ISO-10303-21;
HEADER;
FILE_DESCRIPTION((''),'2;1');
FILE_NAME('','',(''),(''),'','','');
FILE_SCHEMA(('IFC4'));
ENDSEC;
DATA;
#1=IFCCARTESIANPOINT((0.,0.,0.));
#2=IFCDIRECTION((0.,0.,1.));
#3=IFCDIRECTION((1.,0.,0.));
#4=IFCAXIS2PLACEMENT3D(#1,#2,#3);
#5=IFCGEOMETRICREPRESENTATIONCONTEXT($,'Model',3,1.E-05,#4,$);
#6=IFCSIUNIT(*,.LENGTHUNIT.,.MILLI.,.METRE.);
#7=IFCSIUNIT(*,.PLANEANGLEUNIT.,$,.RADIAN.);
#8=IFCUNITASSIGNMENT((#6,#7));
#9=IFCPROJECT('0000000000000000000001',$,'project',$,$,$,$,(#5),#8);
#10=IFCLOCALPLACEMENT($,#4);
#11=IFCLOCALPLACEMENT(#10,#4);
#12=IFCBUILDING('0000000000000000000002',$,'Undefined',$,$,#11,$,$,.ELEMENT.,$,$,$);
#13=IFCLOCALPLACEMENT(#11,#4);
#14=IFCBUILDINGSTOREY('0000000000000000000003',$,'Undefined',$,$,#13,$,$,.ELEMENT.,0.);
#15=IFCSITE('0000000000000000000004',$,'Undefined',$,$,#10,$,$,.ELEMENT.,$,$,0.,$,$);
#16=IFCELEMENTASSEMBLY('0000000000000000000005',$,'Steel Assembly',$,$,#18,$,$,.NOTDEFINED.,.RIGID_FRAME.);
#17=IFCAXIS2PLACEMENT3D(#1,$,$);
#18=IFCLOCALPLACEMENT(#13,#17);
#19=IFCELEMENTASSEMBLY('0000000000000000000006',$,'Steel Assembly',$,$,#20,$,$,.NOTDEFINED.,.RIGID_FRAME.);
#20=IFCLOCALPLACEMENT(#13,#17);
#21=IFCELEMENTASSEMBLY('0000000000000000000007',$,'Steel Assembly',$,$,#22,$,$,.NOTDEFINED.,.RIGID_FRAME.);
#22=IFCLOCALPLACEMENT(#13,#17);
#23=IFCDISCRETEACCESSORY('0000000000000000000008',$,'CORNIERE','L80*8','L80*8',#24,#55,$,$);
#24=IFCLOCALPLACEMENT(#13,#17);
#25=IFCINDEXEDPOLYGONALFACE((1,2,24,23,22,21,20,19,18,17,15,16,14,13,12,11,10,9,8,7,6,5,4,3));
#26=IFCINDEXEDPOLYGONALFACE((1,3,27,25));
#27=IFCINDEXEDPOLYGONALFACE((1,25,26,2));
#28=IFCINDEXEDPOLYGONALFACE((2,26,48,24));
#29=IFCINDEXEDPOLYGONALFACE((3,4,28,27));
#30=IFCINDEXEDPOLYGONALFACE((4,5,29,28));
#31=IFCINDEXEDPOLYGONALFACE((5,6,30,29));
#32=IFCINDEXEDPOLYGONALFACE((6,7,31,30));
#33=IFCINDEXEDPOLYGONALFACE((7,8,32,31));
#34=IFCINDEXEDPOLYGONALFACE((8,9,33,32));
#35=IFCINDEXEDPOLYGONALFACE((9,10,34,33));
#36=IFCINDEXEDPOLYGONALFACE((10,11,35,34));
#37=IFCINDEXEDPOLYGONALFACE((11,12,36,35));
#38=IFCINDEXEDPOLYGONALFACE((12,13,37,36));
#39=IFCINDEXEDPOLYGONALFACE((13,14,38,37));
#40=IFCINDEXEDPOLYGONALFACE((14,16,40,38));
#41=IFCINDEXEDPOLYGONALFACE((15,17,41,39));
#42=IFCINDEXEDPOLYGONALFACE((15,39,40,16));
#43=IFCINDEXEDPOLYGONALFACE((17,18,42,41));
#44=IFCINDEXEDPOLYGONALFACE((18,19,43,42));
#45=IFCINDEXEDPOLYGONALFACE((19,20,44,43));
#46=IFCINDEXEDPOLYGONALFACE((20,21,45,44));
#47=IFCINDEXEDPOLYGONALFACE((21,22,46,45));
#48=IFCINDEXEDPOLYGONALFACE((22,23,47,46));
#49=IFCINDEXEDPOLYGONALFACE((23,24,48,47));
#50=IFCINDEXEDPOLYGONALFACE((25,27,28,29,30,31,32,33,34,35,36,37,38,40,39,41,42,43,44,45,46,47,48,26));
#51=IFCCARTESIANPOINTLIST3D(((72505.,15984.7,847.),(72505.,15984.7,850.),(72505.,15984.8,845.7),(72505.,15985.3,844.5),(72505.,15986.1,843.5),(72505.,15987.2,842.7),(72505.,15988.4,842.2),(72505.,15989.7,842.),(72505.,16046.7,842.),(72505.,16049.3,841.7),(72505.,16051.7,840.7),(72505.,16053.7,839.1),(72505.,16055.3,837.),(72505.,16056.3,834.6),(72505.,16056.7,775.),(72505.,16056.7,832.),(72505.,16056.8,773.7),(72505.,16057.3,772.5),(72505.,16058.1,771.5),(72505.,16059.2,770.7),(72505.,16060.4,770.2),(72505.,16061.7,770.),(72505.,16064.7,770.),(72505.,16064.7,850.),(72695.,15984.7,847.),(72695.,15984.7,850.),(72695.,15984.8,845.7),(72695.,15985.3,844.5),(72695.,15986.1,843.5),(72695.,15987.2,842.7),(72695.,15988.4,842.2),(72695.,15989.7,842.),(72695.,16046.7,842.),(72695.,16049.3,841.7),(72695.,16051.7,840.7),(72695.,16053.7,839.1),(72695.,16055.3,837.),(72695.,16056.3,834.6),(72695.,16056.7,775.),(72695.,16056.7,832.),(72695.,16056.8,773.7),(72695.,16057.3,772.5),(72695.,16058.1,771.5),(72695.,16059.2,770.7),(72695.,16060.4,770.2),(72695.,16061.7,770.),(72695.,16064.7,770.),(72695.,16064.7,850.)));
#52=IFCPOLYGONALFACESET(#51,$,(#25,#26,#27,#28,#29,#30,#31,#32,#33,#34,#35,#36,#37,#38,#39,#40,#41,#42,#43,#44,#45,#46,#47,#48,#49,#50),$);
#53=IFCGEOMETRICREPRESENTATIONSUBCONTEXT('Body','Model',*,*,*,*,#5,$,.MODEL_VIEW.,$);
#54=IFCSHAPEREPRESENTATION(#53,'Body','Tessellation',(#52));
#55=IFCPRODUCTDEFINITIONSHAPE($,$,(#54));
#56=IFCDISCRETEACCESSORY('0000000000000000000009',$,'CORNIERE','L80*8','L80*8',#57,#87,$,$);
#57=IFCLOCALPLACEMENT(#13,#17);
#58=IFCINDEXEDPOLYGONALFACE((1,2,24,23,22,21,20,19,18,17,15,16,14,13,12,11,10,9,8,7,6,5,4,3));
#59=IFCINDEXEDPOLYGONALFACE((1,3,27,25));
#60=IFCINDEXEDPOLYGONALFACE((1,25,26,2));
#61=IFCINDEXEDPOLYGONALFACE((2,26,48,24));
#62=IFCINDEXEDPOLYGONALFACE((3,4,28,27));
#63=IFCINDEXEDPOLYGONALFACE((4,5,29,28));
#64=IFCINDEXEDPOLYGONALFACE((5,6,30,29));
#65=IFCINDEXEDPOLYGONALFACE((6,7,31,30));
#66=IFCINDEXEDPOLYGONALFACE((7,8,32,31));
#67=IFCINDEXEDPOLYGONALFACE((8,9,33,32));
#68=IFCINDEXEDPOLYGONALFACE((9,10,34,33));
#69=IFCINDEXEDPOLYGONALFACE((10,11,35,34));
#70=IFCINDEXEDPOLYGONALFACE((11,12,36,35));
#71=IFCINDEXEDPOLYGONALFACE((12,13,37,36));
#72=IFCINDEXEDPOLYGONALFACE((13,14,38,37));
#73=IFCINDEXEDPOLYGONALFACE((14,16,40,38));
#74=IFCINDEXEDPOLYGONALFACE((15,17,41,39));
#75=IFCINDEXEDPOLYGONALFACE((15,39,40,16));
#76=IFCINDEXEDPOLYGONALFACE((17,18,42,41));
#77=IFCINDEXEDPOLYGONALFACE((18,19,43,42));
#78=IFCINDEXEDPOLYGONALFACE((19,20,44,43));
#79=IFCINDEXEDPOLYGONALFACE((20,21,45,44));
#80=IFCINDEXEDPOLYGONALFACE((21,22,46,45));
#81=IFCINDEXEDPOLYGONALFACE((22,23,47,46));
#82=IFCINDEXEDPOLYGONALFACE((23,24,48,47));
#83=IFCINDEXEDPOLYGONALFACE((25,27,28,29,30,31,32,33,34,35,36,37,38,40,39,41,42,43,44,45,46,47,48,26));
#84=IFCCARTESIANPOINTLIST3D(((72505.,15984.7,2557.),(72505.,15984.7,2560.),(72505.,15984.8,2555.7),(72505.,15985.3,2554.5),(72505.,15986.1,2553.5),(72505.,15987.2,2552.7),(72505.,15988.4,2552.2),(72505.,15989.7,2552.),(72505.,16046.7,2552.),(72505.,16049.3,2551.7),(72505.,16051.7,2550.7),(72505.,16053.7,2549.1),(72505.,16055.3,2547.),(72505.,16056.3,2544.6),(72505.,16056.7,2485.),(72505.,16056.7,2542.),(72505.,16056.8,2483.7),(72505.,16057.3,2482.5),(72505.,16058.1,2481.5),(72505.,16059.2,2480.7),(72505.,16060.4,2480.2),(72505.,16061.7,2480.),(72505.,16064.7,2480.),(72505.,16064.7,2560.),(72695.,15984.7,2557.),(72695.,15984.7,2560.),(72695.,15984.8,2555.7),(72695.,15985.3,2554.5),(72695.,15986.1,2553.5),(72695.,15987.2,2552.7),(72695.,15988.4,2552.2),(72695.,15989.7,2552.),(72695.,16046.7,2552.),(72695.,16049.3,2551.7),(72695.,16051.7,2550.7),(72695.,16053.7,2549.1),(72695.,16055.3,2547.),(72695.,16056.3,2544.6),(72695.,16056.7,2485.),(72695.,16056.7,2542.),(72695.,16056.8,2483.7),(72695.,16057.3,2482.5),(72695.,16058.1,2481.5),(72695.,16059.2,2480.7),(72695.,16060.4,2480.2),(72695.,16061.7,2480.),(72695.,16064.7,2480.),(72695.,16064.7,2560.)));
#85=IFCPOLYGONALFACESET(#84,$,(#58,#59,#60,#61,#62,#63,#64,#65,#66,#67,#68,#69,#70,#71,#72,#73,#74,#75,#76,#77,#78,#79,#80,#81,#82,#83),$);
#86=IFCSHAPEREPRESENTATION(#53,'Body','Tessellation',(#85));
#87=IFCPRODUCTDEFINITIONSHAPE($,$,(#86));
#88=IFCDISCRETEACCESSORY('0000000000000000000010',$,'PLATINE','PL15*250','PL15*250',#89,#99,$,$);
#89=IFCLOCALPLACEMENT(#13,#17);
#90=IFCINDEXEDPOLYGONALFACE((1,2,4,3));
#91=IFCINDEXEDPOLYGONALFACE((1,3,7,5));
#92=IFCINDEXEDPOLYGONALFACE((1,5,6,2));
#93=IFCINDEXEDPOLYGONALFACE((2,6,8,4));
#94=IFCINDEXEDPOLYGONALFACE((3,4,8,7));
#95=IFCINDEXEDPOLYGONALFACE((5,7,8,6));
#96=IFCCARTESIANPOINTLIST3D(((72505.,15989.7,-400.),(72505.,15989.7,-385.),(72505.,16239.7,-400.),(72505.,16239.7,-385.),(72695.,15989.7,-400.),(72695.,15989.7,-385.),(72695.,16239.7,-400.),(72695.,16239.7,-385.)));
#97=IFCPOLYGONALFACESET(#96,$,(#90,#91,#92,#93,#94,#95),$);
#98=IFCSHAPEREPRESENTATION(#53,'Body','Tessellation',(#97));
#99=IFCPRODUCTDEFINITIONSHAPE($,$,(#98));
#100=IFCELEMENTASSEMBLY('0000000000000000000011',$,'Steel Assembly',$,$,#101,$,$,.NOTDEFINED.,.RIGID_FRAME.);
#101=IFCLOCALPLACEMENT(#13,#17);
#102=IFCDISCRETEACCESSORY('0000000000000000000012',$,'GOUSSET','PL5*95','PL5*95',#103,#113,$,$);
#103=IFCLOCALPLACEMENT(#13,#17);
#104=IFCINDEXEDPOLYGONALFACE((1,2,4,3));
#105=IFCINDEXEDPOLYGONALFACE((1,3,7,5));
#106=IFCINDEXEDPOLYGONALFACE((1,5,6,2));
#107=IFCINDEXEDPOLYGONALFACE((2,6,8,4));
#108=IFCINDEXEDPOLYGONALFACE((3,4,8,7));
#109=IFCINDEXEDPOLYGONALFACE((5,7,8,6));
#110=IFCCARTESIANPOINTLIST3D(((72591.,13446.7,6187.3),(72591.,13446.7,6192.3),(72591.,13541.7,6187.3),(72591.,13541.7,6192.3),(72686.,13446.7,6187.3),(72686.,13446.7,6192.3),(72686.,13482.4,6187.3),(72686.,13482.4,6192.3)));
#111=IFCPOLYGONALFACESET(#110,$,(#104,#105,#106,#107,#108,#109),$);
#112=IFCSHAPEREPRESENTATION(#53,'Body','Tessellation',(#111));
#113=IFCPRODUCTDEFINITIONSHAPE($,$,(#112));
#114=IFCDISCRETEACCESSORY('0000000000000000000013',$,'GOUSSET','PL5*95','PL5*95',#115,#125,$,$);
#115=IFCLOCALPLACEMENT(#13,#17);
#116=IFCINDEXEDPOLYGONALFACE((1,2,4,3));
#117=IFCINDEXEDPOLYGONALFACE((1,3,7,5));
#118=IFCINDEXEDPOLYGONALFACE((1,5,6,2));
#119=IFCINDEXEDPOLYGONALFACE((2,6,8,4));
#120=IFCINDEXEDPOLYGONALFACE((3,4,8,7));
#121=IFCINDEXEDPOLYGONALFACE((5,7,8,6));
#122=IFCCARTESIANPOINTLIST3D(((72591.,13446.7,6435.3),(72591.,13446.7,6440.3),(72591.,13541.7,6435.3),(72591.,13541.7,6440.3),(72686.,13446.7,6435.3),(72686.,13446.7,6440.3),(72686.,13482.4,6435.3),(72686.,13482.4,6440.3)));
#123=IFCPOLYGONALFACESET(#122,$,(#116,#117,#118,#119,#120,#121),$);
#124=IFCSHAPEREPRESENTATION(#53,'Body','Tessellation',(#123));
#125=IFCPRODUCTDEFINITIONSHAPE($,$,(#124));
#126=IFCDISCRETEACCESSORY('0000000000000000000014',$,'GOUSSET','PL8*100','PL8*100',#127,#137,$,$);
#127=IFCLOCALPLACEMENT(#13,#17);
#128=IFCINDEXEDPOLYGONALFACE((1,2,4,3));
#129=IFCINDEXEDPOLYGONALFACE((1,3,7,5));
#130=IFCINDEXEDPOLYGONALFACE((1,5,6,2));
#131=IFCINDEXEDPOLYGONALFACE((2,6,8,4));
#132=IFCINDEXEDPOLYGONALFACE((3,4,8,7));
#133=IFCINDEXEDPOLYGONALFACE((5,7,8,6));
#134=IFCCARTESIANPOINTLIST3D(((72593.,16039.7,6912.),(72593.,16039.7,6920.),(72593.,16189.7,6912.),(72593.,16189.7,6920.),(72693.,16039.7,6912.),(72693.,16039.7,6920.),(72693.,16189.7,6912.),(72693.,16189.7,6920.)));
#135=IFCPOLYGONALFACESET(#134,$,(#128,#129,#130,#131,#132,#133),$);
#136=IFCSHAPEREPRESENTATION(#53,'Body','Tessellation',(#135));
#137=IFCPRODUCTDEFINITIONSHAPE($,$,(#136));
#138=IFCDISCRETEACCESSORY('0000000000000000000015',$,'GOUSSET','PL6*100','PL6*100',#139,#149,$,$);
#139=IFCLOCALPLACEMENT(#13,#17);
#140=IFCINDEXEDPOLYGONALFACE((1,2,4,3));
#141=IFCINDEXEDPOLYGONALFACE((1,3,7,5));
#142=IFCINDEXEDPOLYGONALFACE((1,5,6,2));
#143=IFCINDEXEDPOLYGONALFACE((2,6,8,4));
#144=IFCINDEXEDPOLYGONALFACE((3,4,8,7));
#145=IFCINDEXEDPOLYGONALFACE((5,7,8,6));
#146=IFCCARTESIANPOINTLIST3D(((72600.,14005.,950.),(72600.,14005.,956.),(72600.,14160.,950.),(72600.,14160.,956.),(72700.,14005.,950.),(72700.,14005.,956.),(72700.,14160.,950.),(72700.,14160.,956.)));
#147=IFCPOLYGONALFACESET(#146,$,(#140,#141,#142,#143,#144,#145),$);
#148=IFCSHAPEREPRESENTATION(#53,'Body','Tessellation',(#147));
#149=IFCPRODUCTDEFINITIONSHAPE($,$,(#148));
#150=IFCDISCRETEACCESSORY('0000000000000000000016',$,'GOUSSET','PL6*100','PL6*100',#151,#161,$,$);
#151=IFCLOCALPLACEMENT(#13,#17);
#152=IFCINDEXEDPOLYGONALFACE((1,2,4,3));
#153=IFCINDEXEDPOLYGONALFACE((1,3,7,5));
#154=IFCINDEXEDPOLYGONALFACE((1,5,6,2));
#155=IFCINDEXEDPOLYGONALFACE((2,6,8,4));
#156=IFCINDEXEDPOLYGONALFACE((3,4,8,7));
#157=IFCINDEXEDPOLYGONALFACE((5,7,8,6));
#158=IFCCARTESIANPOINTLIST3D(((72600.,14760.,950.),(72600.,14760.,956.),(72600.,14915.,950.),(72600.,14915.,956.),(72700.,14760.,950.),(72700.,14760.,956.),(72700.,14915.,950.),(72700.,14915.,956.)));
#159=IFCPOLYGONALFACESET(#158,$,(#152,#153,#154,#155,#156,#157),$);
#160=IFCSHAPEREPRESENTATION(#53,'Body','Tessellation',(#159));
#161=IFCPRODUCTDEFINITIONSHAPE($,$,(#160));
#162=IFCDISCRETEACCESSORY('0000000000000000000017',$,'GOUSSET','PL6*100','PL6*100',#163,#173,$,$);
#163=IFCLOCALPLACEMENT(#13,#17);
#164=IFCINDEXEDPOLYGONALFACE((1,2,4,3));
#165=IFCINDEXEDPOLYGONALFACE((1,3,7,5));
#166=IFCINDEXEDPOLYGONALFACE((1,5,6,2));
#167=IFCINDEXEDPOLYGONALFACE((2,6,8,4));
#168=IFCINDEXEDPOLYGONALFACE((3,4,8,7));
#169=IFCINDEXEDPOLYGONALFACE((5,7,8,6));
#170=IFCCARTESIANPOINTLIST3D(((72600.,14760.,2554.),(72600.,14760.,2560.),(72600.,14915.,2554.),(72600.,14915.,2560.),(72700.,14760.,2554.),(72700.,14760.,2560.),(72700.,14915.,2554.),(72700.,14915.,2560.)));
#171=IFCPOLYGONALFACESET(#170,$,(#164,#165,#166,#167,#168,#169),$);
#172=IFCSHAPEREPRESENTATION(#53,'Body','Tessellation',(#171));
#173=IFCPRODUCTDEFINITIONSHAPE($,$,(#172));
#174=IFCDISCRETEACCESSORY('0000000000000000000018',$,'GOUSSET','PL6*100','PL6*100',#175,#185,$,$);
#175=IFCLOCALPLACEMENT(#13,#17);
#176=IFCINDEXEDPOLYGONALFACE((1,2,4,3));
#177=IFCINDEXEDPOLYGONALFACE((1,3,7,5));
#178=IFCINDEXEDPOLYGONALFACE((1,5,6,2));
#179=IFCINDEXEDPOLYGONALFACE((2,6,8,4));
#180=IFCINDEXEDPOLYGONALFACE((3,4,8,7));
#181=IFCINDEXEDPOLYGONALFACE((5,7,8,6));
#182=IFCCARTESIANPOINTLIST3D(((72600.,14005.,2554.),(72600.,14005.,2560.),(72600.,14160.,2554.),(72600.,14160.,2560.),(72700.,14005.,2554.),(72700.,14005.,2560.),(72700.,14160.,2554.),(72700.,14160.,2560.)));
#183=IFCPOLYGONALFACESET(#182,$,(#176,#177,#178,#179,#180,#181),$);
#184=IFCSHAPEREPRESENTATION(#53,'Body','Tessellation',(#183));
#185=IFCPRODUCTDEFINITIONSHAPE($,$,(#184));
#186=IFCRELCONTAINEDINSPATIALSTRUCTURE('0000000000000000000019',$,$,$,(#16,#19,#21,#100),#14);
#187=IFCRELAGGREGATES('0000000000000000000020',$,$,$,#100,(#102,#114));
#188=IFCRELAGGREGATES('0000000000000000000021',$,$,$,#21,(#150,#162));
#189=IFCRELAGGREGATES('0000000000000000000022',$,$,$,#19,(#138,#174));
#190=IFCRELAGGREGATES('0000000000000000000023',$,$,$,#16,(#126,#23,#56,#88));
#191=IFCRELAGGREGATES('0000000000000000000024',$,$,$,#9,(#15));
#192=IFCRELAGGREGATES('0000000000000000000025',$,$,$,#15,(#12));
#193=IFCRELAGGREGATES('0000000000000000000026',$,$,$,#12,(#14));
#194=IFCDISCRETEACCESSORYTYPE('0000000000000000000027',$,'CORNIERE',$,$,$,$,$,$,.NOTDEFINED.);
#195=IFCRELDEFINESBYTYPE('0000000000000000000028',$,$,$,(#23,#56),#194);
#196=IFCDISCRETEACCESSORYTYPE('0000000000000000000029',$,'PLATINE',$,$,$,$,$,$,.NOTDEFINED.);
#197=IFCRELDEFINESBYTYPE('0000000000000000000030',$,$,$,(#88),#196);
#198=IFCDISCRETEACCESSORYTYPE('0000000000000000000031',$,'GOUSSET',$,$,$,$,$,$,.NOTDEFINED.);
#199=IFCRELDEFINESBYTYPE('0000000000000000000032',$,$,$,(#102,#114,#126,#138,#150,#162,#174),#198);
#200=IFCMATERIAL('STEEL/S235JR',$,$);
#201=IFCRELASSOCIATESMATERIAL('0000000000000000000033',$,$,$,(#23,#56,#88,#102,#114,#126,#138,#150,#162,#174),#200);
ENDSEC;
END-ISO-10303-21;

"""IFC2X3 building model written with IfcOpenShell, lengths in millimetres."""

from ifc_helpers import new_model, si_unit, frame, origin_with_axes, origin_2d_with_axis, place, context, subcontext, project, spatial, polyline, l_section, outline, extrude, material, type_object, element, aggregate, save


model = new_model("IFC2X3")

# Units and contexts
model_context = context("Model", 3, precision=1e-05, world=origin_with_axes())
body_context = subcontext(model_context, "Body", "Model", "MODEL_VIEW")
ifc_project = project(units=[si_unit("LENGTHUNIT", "METRE", prefix="MILLI"), si_unit("PLANEANGLEUNIT", "RADIAN")], contexts=[model_context])

# Site, building, storey
site_placement = place(None, origin_with_axes())
site = spatial("IfcSite", under=ifc_project, at=site_placement, Name="Undefined", CompositionType="ELEMENT", RefElevation=0.0)
building_placement = place(site_placement, origin_with_axes())
building = spatial("IfcBuilding", under=site, at=building_placement, Name="Undefined", CompositionType="ELEMENT")
storey_placement = place(building_placement, origin_with_axes())
storey = spatial("IfcBuildingStorey", under=building, at=storey_placement, Name="Undefined", CompositionType="ELEMENT", Elevation=0.0)

# Element assembly
assembly_1_placement = place(storey_placement, origin_with_axes())
assembly_1 = element("IfcElementAssembly", 1, at=assembly_1_placement, inside=storey, Name="Steel Assembly", AssemblyPlace="NOTDEFINED", PredefinedType="RIGID_FRAME")
ifc_material_1 = material(Name="STEEL/S235JR")

# Element assemblies
assembly_2_placement = place(storey_placement, origin_with_axes())
assembly_2 = element("IfcElementAssembly", 2, at=assembly_2_placement, inside=storey, Name="Steel Assembly", AssemblyPlace="NOTDEFINED", PredefinedType="RIGID_FRAME")
assembly_3_placement = place(storey_placement, origin_with_axes())
assembly_3 = element("IfcElementAssembly", 3, at=assembly_3_placement, inside=storey, Name="Steel Assembly", AssemblyPlace="NOTDEFINED", PredefinedType="RIGID_FRAME")

# Discrete accessories
discrete_accessory_type_1 = type_object("IfcDiscreteAccessoryType", Name="CORNIERE")
discrete_accessory_1_placement = place(assembly_1_placement, frame((72695.0, 16024.7, 810.0), z_axis=(0.0, 0.0, -1.0), x_axis=(-1.0, 0.0, 0.0)))
discrete_accessory_1 = element("IfcDiscreteAccessory", 4, at=discrete_accessory_1_placement, type_object=discrete_accessory_type_1, material=ifc_material_1, Name="CORNIERE", Description="L80*8", ObjectType="L80*8", context=body_context, shape_type="SweptSolid", body=[
    extrude(l_section(Depth=80.0, Width=80.0, Thickness=8.0, FilletRadius=10.0, EdgeRadius=5.0, at=origin_2d_with_axis()), frame((190.0, 0.0, 0.0), z_axis=(-1.0, 0.0, 0.0), x_axis=(0.0, -1.0, 0.0)), (0.0, 0.0, 1.0), 190.0),
])
discrete_accessory_2_placement = place(assembly_1_placement, frame((72695.0, 16024.7, 2520.0), z_axis=(0.0, 0.0, -1.0), x_axis=(-1.0, 0.0, 0.0)))
discrete_accessory_2 = element("IfcDiscreteAccessory", 5, at=discrete_accessory_2_placement, type_object=discrete_accessory_type_1, material=ifc_material_1, Name="CORNIERE", Description="L80*8", ObjectType="L80*8", context=body_context, shape_type="SweptSolid", body=[
    extrude(l_section(Depth=80.0, Width=80.0, Thickness=8.0, FilletRadius=10.0, EdgeRadius=5.0, at=origin_2d_with_axis()), frame((190.0, 0.0, 0.0), z_axis=(-1.0, 0.0, 0.0), x_axis=(0.0, -1.0, 0.0)), (0.0, 0.0, 1.0), 190.0),
])
discrete_accessory_type_2 = type_object("IfcDiscreteAccessoryType", Name="PLATINE")
discrete_accessory_3_placement = place(assembly_1_placement, frame((72505.0, 16114.7, -392.5), z_axis=(0.0, 0.0, 1.0), x_axis=(1.0, 0.0, 0.0)))
discrete_accessory_3 = element("IfcDiscreteAccessory", 6, at=discrete_accessory_3_placement, type_object=discrete_accessory_type_2, material=ifc_material_1, Name="PLATINE", Description="PL15*250", ObjectType="PL15*250", context=body_context, shape_type="SweptSolid", body=[
    extrude(outline(polyline([(0.0, 125.0), (190.0, 125.0), (190.0, -125.0), (0.0, -125.0), (0.0, 125.0)])), frame((0.0, 0.0, -7.5), z_axis=(0.0, 0.0, 1.0), x_axis=(1.0, 0.0, 0.0)), (0.0, 0.0, 1.0), 15.0),
])

# Element assembly, discrete accessories
assembly_4_placement = place(storey_placement, origin_with_axes())
assembly_4 = element("IfcElementAssembly", 7, at=assembly_4_placement, inside=storey, Name="Steel Assembly", AssemblyPlace="NOTDEFINED", PredefinedType="RIGID_FRAME")
discrete_accessory_type_3 = type_object("IfcDiscreteAccessoryType", Name="GOUSSET")
discrete_accessory_4_placement = place(assembly_4_placement, frame((72686.0, 13446.7, 6189.8), z_axis=(0.0, 0.0, -1.0), x_axis=(-1.0, 0.0, 0.0)))
discrete_accessory_4 = element("IfcDiscreteAccessory", 8, at=discrete_accessory_4_placement, type_object=discrete_accessory_type_3, material=ifc_material_1, Name="GOUSSET", Description="PL5*95", ObjectType="PL5*95", context=body_context, shape_type="SweptSolid", body=[
    extrude(outline(polyline([(0.0, 0.0), (95.0, 0.0), (95.0, 95.0), (0.0, 35.7), (0.0, 0.0)])), frame((0.0, 0.0, -2.5), z_axis=(0.0, 0.0, 1.0), x_axis=(1.0, 0.0, 0.0)), (0.0, 0.0, 1.0), 5.0),
])
discrete_accessory_5_placement = place(assembly_4_placement, frame((72686.0, 13446.7, 6437.8), z_axis=(0.0, 0.0, -1.0), x_axis=(-1.0, 0.0, 0.0)))
discrete_accessory_5 = element("IfcDiscreteAccessory", 9, at=discrete_accessory_5_placement, type_object=discrete_accessory_type_3, material=ifc_material_1, Name="GOUSSET", Description="PL5*95", ObjectType="PL5*95", context=body_context, shape_type="SweptSolid", body=[
    extrude(outline(polyline([(0.0, 0.0), (95.0, 0.0), (95.0, 95.0), (0.0, 35.7), (0.0, 0.0)])), frame((0.0, 0.0, -2.5), z_axis=(0.0, 0.0, 1.0), x_axis=(1.0, 0.0, 0.0)), (0.0, 0.0, 1.0), 5.0),
])
aggregate(assembly_4, [discrete_accessory_4, discrete_accessory_5])

# Discrete accessories
discrete_accessory_6_placement = place(assembly_1_placement, frame((72693.0, 16039.7, 6916.0), z_axis=(0.0, 0.0, 1.0), x_axis=(0.0, 1.0, 0.0)))
discrete_accessory_6 = element("IfcDiscreteAccessory", 10, at=discrete_accessory_6_placement, type_object=discrete_accessory_type_3, material=ifc_material_1, Name="GOUSSET", Description="PL8*100", ObjectType="PL8*100", context=body_context, shape_type="SweptSolid", body=[
    extrude(outline(polyline([(0.0, 0.0), (150.0, 0.0), (150.0, 100.0), (0.0, 100.0), (0.0, 0.0)])), frame((0.0, 0.0, -4.0), z_axis=(0.0, 0.0, 1.0), x_axis=(1.0, 0.0, 0.0)), (0.0, 0.0, 1.0), 8.0),
])
discrete_accessory_7_placement = place(assembly_2_placement, frame((72600.0, 14160.0, 953.0), z_axis=(0.0, 0.0, 1.0), x_axis=(0.0, -1.0, 0.0)))
discrete_accessory_7 = element("IfcDiscreteAccessory", 11, at=discrete_accessory_7_placement, type_object=discrete_accessory_type_3, material=ifc_material_1, Name="GOUSSET", Description="PL6*100", ObjectType="PL6*100", context=body_context, shape_type="SweptSolid", body=[
    extrude(outline(polyline([(0.0, 0.0), (155.0, 0.0), (155.0, 100.0), (0.0, 100.0), (0.0, 0.0)])), frame((0.0, 0.0, -3.0), z_axis=(0.0, 0.0, 1.0), x_axis=(1.0, 0.0, 0.0)), (0.0, 0.0, 1.0), 6.0),
])
discrete_accessory_8_placement = place(assembly_3_placement, frame((72700.0, 14760.0, 953.0), z_axis=(0.0, 0.0, 1.0), x_axis=(0.0, 1.0, 0.0)))
discrete_accessory_8 = element("IfcDiscreteAccessory", 12, at=discrete_accessory_8_placement, type_object=discrete_accessory_type_3, material=ifc_material_1, Name="GOUSSET", Description="PL6*100", ObjectType="PL6*100", context=body_context, shape_type="SweptSolid", body=[
    extrude(outline(polyline([(0.0, 0.0), (155.0, 0.0), (155.0, 100.0), (0.0, 100.0), (0.0, 0.0)])), frame((0.0, 0.0, -3.0), z_axis=(0.0, 0.0, 1.0), x_axis=(1.0, 0.0, 0.0)), (0.0, 0.0, 1.0), 6.0),
])
discrete_accessory_9_placement = place(assembly_3_placement, frame((72600.0, 14760.0, 2557.0), z_axis=(0.0, 0.0, -1.0), x_axis=(0.0, 1.0, 0.0)))
discrete_accessory_9 = element("IfcDiscreteAccessory", 13, at=discrete_accessory_9_placement, type_object=discrete_accessory_type_3, material=ifc_material_1, Name="GOUSSET", Description="PL6*100", ObjectType="PL6*100", context=body_context, shape_type="SweptSolid", body=[
    extrude(outline(polyline([(0.0, 0.0), (155.0, 0.0), (155.0, 100.0), (0.0, 100.0), (0.0, 0.0)])), frame((0.0, 0.0, -3.0), z_axis=(0.0, 0.0, 1.0), x_axis=(1.0, 0.0, 0.0)), (0.0, 0.0, 1.0), 6.0),
])
aggregate(assembly_3, [discrete_accessory_8, discrete_accessory_9])
discrete_accessory_10_placement = place(assembly_2_placement, frame((72700.0, 14160.0, 2557.0), z_axis=(0.0, 0.0, -1.0), x_axis=(0.0, -1.0, 0.0)))
discrete_accessory_10 = element("IfcDiscreteAccessory", 14, at=discrete_accessory_10_placement, type_object=discrete_accessory_type_3, material=ifc_material_1, Name="GOUSSET", Description="PL6*100", ObjectType="PL6*100", context=body_context, shape_type="SweptSolid", body=[
    extrude(outline(polyline([(0.0, 0.0), (155.0, 0.0), (155.0, 100.0), (0.0, 100.0), (0.0, 0.0)])), frame((0.0, 0.0, -3.0), z_axis=(0.0, 0.0, 1.0), x_axis=(1.0, 0.0, 0.0)), (0.0, 0.0, 1.0), 6.0),
])
aggregate(assembly_2, [discrete_accessory_7, discrete_accessory_10])

aggregate(assembly_1, [discrete_accessory_6, discrete_accessory_1, discrete_accessory_2, discrete_accessory_3])

save(model, "model.ifc")
